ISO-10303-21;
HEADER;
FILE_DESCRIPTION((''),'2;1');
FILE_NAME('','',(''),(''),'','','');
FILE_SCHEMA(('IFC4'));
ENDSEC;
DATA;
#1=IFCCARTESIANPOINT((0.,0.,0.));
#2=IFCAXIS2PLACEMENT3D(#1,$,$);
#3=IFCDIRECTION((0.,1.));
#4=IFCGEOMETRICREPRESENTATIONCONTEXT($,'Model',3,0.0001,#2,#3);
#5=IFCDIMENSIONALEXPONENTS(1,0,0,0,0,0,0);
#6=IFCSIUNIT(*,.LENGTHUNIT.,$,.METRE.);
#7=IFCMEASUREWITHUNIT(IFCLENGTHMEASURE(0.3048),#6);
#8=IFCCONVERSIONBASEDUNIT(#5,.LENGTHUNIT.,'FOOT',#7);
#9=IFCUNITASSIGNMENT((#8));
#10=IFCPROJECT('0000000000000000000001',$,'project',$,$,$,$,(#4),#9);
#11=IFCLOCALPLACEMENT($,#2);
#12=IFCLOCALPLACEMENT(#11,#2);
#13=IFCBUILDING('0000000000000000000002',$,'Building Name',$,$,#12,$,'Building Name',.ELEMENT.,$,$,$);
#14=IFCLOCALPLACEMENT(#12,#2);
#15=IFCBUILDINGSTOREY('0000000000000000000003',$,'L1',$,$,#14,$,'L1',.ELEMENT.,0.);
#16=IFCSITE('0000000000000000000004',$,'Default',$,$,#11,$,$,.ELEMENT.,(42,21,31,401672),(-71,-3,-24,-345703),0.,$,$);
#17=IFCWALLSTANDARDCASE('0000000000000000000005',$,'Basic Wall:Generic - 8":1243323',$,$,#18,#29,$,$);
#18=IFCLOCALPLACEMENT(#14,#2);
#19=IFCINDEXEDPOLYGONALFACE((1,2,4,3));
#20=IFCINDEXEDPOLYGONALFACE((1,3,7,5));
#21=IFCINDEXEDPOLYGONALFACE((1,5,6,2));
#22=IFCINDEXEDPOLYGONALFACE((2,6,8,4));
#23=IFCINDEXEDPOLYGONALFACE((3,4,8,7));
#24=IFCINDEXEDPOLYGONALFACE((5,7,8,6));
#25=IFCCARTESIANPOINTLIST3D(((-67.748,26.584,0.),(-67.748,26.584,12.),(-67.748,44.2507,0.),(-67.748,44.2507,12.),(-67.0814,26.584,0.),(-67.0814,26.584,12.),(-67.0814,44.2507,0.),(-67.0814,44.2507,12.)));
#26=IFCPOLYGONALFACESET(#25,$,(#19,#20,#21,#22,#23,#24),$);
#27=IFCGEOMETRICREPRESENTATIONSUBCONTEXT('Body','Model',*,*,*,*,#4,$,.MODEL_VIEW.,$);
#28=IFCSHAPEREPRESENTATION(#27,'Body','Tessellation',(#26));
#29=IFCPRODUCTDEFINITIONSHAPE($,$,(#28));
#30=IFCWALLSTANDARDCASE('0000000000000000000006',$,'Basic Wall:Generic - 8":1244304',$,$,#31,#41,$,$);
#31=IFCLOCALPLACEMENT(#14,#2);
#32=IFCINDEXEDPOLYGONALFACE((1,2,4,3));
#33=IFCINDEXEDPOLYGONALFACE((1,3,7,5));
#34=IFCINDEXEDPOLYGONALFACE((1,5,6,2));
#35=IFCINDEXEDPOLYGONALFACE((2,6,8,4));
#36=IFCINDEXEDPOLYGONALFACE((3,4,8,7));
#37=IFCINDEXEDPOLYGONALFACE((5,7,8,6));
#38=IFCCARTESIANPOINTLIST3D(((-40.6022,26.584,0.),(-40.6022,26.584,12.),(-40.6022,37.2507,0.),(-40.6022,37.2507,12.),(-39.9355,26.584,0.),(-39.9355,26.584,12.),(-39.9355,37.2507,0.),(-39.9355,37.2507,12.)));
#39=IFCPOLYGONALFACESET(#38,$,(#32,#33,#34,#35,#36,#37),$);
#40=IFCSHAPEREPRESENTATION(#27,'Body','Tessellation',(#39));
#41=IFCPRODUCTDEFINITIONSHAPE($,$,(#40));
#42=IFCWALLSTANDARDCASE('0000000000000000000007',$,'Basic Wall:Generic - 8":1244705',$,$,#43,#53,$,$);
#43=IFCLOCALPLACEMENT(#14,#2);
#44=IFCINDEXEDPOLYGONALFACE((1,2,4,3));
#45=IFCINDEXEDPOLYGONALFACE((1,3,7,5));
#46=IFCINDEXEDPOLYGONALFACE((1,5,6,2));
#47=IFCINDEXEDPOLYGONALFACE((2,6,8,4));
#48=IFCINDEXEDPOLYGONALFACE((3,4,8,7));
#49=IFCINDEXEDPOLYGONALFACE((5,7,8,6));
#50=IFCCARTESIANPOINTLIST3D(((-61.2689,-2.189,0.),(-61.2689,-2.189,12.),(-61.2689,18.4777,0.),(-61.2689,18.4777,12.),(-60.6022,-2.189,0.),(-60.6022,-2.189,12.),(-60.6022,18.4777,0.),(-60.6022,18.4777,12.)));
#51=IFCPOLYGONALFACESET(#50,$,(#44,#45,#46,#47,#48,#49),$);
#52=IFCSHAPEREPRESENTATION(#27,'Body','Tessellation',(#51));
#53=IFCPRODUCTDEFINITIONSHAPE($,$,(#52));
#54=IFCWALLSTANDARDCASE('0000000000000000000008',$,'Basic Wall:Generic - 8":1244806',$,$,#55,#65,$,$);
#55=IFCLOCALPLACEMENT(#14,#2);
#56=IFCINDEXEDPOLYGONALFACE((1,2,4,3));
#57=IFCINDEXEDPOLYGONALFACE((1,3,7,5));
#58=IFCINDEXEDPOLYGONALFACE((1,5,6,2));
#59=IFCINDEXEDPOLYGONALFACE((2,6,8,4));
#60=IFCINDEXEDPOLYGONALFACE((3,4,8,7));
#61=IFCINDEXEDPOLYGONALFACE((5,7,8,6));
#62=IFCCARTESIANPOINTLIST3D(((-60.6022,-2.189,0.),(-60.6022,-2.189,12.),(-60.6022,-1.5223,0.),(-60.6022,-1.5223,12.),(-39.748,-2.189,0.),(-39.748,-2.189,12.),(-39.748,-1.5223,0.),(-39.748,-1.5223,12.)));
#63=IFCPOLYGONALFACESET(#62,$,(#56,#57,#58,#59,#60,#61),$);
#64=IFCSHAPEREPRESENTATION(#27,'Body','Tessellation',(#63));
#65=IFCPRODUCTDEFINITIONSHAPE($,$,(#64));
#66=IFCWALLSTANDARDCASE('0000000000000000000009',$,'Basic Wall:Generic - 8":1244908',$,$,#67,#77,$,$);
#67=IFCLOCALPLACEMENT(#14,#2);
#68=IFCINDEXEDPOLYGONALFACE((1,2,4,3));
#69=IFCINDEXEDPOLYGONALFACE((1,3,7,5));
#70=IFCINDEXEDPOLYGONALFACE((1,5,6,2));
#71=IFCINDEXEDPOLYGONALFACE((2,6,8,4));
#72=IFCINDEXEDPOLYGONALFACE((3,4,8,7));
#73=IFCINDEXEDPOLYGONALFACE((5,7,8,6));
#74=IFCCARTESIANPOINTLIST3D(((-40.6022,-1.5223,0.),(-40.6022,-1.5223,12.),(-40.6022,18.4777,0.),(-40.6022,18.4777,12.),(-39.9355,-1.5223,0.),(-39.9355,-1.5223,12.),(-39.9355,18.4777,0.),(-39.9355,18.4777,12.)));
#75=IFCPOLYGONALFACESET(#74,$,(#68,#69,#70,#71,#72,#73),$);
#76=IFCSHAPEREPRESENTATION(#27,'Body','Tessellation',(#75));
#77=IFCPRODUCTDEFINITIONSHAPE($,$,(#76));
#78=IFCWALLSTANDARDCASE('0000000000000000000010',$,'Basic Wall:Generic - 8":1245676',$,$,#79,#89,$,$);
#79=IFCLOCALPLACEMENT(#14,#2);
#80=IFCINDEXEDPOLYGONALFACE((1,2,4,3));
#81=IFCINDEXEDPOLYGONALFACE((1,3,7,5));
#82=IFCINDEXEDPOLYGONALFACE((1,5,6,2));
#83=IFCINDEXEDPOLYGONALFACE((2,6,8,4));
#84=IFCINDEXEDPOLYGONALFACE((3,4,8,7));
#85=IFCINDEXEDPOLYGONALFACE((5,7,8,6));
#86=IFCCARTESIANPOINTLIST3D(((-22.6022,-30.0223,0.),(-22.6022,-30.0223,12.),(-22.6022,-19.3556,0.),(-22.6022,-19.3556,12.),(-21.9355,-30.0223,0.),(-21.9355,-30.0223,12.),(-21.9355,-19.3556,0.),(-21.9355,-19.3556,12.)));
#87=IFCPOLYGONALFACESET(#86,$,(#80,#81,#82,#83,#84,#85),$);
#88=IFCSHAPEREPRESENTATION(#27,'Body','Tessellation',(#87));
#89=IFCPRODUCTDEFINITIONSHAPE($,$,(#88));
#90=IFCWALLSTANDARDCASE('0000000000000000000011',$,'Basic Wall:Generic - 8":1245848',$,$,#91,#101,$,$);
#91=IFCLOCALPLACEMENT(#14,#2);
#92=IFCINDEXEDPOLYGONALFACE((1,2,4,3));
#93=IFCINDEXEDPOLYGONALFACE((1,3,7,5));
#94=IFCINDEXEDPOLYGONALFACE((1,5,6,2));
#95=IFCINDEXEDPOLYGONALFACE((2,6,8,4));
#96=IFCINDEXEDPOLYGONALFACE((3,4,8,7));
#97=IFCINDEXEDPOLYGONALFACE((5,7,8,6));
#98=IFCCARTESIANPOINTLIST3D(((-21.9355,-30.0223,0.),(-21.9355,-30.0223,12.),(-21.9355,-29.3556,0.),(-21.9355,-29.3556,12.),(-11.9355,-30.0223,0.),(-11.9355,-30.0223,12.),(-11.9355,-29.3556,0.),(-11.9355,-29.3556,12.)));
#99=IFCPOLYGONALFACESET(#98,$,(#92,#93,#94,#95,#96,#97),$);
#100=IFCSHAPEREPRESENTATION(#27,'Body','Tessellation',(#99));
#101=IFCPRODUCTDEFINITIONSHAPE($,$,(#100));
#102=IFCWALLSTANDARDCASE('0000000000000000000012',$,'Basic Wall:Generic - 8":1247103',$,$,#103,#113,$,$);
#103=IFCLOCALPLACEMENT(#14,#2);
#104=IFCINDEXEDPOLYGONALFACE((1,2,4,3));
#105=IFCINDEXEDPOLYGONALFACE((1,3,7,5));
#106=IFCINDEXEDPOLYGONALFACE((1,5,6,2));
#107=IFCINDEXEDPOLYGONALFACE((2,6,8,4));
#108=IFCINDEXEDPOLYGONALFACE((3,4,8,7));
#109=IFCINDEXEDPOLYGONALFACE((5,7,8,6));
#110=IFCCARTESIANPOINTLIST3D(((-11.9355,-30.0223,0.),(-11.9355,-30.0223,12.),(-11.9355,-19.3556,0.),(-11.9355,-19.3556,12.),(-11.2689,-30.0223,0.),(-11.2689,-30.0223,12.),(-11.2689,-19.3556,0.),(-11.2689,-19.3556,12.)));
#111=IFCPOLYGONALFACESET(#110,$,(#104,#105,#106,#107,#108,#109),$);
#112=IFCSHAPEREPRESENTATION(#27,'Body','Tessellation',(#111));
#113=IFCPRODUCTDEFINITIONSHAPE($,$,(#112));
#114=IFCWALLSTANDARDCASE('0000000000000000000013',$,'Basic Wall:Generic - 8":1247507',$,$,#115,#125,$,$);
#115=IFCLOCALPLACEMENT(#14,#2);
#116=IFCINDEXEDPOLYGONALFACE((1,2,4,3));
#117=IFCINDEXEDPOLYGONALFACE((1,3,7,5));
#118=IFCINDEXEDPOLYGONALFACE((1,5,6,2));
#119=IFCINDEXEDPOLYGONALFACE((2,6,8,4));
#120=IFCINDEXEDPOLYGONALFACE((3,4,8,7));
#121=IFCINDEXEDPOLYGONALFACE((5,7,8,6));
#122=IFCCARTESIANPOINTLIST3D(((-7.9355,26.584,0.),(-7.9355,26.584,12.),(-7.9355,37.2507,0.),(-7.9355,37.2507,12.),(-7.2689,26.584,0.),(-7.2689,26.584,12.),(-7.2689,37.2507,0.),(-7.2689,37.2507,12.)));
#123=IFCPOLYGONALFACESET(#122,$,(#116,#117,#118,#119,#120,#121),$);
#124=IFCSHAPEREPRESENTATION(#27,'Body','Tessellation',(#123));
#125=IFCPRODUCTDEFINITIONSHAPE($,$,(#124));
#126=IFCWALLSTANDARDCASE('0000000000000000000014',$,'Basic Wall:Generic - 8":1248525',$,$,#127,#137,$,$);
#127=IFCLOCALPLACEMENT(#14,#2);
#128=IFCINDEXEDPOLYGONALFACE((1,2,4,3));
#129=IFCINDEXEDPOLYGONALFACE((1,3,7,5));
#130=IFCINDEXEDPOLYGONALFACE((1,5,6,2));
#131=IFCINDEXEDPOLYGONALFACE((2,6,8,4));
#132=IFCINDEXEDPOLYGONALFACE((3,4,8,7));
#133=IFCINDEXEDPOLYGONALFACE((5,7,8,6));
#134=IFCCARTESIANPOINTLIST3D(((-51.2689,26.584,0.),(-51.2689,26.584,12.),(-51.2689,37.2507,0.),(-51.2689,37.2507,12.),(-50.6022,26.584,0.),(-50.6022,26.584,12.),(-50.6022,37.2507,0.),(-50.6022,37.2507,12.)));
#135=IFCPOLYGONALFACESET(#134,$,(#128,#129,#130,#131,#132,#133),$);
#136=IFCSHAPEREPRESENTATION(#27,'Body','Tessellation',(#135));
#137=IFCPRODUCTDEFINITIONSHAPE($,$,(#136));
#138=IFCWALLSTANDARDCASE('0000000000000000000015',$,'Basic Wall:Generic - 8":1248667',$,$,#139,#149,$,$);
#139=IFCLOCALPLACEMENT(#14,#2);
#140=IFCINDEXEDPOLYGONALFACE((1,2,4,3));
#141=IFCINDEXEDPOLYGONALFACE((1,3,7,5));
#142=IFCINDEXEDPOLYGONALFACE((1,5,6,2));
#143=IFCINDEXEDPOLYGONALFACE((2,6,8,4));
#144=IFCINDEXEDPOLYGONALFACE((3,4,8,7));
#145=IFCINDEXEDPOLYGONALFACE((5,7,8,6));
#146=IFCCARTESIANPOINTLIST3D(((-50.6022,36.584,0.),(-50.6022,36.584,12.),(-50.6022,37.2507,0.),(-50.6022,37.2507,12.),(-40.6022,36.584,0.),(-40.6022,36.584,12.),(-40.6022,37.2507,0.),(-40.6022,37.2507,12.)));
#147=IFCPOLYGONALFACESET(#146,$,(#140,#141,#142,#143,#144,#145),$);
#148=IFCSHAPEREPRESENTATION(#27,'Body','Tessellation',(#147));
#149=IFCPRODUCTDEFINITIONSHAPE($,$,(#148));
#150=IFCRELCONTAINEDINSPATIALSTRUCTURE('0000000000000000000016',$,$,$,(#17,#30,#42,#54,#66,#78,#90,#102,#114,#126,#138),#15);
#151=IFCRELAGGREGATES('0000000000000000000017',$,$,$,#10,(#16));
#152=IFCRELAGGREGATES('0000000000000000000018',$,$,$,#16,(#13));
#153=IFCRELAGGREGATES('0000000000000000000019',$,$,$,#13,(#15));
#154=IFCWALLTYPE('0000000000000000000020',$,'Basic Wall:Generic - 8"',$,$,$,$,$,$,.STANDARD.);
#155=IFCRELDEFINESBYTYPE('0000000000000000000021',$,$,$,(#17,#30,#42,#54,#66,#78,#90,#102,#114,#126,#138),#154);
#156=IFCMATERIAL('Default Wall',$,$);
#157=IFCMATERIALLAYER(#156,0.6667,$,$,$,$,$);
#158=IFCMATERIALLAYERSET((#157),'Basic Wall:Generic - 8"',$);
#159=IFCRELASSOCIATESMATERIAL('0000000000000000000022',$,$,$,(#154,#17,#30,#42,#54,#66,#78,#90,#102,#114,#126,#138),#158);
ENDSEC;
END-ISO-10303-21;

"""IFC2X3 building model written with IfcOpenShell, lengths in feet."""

from ifc_helpers import new_model, entity, si_unit, converted_unit, direction, frame, frame_2d, origin, place, context, subcontext, project, spatial, rectangle, extrude, material, layer, layer_set, layer_usage, type_object, element, save


model = new_model("IFC2X3")

# Units and contexts
model_context = context("Model", 3, precision=0.0001, world=origin(), true_north=direction((0.0, 1.0)))
body_context = subcontext(model_context, "Body", "Model", "MODEL_VIEW")
ifc_project = project(units=[converted_unit("LENGTHUNIT", "FOOT", entity("IfcLengthMeasure", 0.3048), si_unit("LENGTHUNIT", "METRE"), dimensions=[1, 0, 0, 0, 0, 0, 0])], contexts=[model_context])

# Site, building, storey
site_placement = place(None, origin())
site = spatial("IfcSite", under=ifc_project, at=site_placement, Name="Default", CompositionType="ELEMENT", RefLatitude=(42, 21, 31, 401672), RefLongitude=(-71, -3, -24, -345703), RefElevation=0.0)
building_placement = place(site_placement, origin())
building = spatial("IfcBuilding", under=site, at=building_placement, Name="Building Name", LongName="Building Name", CompositionType="ELEMENT")
storey_placement = place(building_placement, origin())
storey = spatial("IfcBuildingStorey", under=building, at=storey_placement, Name="L1", LongName="L1", CompositionType="ELEMENT", Elevation=0.0)

# Walls
ifc_material_1 = material(Name="Default Wall")
ifc_layer_1 = layer(ifc_material_1, 0.6667)
ifc_layer_set_1 = layer_set([ifc_layer_1], Name="Basic Wall:Generic - 8\"")
wall_type_1 = type_object("IfcWallType", Name="Basic Wall:Generic - 8\"", PredefinedType="STANDARD", material=ifc_layer_set_1)
ifc_layer_usage_1 = layer_usage(ifc_layer_set_1, "AXIS2", "NEGATIVE", 0.3333)
wall_1_placement = place(storey_placement, frame((-67.4147, 44.2507, 0.0), z_axis=(0.0, 0.0, 1.0), x_axis=(0.0, -1.0, 0.0)))
element("IfcWallStandardCase", 1, at=wall_1_placement, inside=storey, type_object=wall_type_1, material=ifc_layer_usage_1, Name="Basic Wall:Generic - 8\":1243323", context=body_context, shape_type="SweptSolid", body=[
    extrude(rectangle(XDim=17.6667, YDim=0.6667, at=frame_2d((8.8333, 0.0), x_axis=(-1.0, 0.0))), origin(), (0.0, 0.0, 1.0), 12.0),
])
ifc_layer_usage_2 = layer_usage(ifc_layer_set_1, "AXIS2", "NEGATIVE", 0.3333)
wall_2_placement = place(storey_placement, frame((-40.2689, 26.584, 0.0), z_axis=(0.0, 0.0, 1.0), x_axis=(0.0, 1.0, 0.0)))
element("IfcWallStandardCase", 2, at=wall_2_placement, inside=storey, type_object=wall_type_1, material=ifc_layer_usage_2, Name="Basic Wall:Generic - 8\":1244304", context=body_context, shape_type="SweptSolid", body=[
    extrude(rectangle(XDim=10.6667, YDim=0.6667, at=frame_2d((5.3333, 0.0), x_axis=(-1.0, 0.0))), origin(), (0.0, 0.0, 1.0), 12.0),
])
ifc_layer_usage_3 = layer_usage(ifc_layer_set_1, "AXIS2", "NEGATIVE", 0.3333)
wall_3_placement = place(storey_placement, frame((-60.9355, 18.4777, 0.0), z_axis=(0.0, 0.0, 1.0), x_axis=(0.0, -1.0, 0.0)))
element("IfcWallStandardCase", 3, at=wall_3_placement, inside=storey, type_object=wall_type_1, material=ifc_layer_usage_3, Name="Basic Wall:Generic - 8\":1244705", context=body_context, shape_type="SweptSolid", body=[
    extrude(rectangle(XDim=20.6667, YDim=0.6667, at=frame_2d((10.3333, 0.0), x_axis=(-1.0, 0.0))), origin(), (0.0, 0.0, 1.0), 12.0),
])
ifc_layer_usage_4 = layer_usage(ifc_layer_set_1, "AXIS2", "NEGATIVE", 0.3333)
wall_4_placement = place(storey_placement, frame((-60.6022, -1.8556, 0.0)))
element("IfcWallStandardCase", 4, at=wall_4_placement, inside=storey, type_object=wall_type_1, material=ifc_layer_usage_4, Name="Basic Wall:Generic - 8\":1244806", context=body_context, shape_type="SweptSolid", body=[
    extrude(rectangle(XDim=20.8542, YDim=0.6667, at=frame_2d((10.4271, 0.0), x_axis=(-1.0, 0.0))), origin(), (0.0, 0.0, 1.0), 12.0),
])
ifc_layer_usage_5 = layer_usage(ifc_layer_set_1, "AXIS2", "POSITIVE", -0.3333)
wall_5_placement = place(storey_placement, frame((-40.2689, 18.4777, 0.0), z_axis=(0.0, 0.0, 1.0), x_axis=(0.0, -1.0, 0.0)))
element("IfcWallStandardCase", 5, at=wall_5_placement, inside=storey, type_object=wall_type_1, material=ifc_layer_usage_5, Name="Basic Wall:Generic - 8\":1244908", context=body_context, shape_type="SweptSolid", body=[
    extrude(rectangle(XDim=20.0, YDim=0.6667, at=frame_2d((10.0, 0.0), x_axis=(-1.0, 0.0))), origin(), (0.0, 0.0, 1.0), 12.0),
])
ifc_layer_usage_6 = layer_usage(ifc_layer_set_1, "AXIS2", "POSITIVE", -0.3333)
wall_6_placement = place(storey_placement, frame((-22.2689, -19.3556, 0.0), z_axis=(0.0, 0.0, 1.0), x_axis=(0.0, -1.0, 0.0)))
element("IfcWallStandardCase", 6, at=wall_6_placement, inside=storey, type_object=wall_type_1, material=ifc_layer_usage_6, Name="Basic Wall:Generic - 8\":1245676", context=body_context, shape_type="SweptSolid", body=[
    extrude(rectangle(XDim=10.6667, YDim=0.6667, at=frame_2d((5.3333, 0.0), x_axis=(-1.0, 0.0))), origin(), (0.0, 0.0, 1.0), 12.0),
])
ifc_layer_usage_7 = layer_usage(ifc_layer_set_1, "AXIS2", "POSITIVE", -0.3333)
wall_7_placement = place(storey_placement, frame((-21.9355, -29.689, 0.0)))
element("IfcWallStandardCase", 7, at=wall_7_placement, inside=storey, type_object=wall_type_1, material=ifc_layer_usage_7, Name="Basic Wall:Generic - 8\":1245848", context=body_context, shape_type="SweptSolid", body=[
    extrude(rectangle(XDim=10.0, YDim=0.6667, at=frame_2d((5.0, 0.0), x_axis=(-1.0, 0.0))), origin(), (0.0, 0.0, 1.0), 12.0),
])
ifc_layer_usage_8 = layer_usage(ifc_layer_set_1, "AXIS2", "NEGATIVE", 0.3333)
wall_8_placement = place(storey_placement, frame((-11.6022, -19.3556, 0.0), z_axis=(0.0, 0.0, 1.0), x_axis=(0.0, -1.0, 0.0)))
element("IfcWallStandardCase", 8, at=wall_8_placement, inside=storey, type_object=wall_type_1, material=ifc_layer_usage_8, Name="Basic Wall:Generic - 8\":1247103", context=body_context, shape_type="SweptSolid", body=[
    extrude(rectangle(XDim=10.6667, YDim=0.6667, at=frame_2d((5.3333, 0.0), x_axis=(-1.0, 0.0))), origin(), (0.0, 0.0, 1.0), 12.0),
])
ifc_layer_usage_9 = layer_usage(ifc_layer_set_1, "AXIS2", "POSITIVE", -0.3333)
wall_9_placement = place(storey_placement, frame((-7.6022, 37.2507, 0.0), z_axis=(0.0, 0.0, 1.0), x_axis=(0.0, -1.0, 0.0)))
element("IfcWallStandardCase", 9, at=wall_9_placement, inside=storey, type_object=wall_type_1, material=ifc_layer_usage_9, Name="Basic Wall:Generic - 8\":1247507", context=body_context, shape_type="SweptSolid", body=[
    extrude(rectangle(XDim=10.6667, YDim=0.6667, at=frame_2d((5.3333, 0.0), x_axis=(-1.0, 0.0))), origin(), (0.0, 0.0, 1.0), 12.0),
])
ifc_layer_usage_10 = layer_usage(ifc_layer_set_1, "AXIS2", "NEGATIVE", 0.3333)
wall_10_placement = place(storey_placement, frame((-50.9355, 26.584, 0.0), z_axis=(0.0, 0.0, 1.0), x_axis=(0.0, 1.0, 0.0)))
element("IfcWallStandardCase", 10, at=wall_10_placement, inside=storey, type_object=wall_type_1, material=ifc_layer_usage_10, Name="Basic Wall:Generic - 8\":1248525", context=body_context, shape_type="SweptSolid", body=[
    extrude(rectangle(XDim=10.6667, YDim=0.6667, at=frame_2d((5.3333, 0.0), x_axis=(-1.0, 0.0))), origin(), (0.0, 0.0, 1.0), 12.0),
])
ifc_layer_usage_11 = layer_usage(ifc_layer_set_1, "AXIS2", "POSITIVE", -0.3333)
wall_11_placement = place(storey_placement, frame((-50.6022, 36.9174, 0.0)))
element("IfcWallStandardCase", 11, at=wall_11_placement, inside=storey, type_object=wall_type_1, material=ifc_layer_usage_11, Name="Basic Wall:Generic - 8\":1248667", context=body_context, shape_type="SweptSolid", body=[
    extrude(rectangle(XDim=10.0, YDim=0.6667, at=frame_2d((5.0, 0.0), x_axis=(-1.0, 0.0))), origin(), (0.0, 0.0, 1.0), 12.0),
])

save(model, "model.ifc")
